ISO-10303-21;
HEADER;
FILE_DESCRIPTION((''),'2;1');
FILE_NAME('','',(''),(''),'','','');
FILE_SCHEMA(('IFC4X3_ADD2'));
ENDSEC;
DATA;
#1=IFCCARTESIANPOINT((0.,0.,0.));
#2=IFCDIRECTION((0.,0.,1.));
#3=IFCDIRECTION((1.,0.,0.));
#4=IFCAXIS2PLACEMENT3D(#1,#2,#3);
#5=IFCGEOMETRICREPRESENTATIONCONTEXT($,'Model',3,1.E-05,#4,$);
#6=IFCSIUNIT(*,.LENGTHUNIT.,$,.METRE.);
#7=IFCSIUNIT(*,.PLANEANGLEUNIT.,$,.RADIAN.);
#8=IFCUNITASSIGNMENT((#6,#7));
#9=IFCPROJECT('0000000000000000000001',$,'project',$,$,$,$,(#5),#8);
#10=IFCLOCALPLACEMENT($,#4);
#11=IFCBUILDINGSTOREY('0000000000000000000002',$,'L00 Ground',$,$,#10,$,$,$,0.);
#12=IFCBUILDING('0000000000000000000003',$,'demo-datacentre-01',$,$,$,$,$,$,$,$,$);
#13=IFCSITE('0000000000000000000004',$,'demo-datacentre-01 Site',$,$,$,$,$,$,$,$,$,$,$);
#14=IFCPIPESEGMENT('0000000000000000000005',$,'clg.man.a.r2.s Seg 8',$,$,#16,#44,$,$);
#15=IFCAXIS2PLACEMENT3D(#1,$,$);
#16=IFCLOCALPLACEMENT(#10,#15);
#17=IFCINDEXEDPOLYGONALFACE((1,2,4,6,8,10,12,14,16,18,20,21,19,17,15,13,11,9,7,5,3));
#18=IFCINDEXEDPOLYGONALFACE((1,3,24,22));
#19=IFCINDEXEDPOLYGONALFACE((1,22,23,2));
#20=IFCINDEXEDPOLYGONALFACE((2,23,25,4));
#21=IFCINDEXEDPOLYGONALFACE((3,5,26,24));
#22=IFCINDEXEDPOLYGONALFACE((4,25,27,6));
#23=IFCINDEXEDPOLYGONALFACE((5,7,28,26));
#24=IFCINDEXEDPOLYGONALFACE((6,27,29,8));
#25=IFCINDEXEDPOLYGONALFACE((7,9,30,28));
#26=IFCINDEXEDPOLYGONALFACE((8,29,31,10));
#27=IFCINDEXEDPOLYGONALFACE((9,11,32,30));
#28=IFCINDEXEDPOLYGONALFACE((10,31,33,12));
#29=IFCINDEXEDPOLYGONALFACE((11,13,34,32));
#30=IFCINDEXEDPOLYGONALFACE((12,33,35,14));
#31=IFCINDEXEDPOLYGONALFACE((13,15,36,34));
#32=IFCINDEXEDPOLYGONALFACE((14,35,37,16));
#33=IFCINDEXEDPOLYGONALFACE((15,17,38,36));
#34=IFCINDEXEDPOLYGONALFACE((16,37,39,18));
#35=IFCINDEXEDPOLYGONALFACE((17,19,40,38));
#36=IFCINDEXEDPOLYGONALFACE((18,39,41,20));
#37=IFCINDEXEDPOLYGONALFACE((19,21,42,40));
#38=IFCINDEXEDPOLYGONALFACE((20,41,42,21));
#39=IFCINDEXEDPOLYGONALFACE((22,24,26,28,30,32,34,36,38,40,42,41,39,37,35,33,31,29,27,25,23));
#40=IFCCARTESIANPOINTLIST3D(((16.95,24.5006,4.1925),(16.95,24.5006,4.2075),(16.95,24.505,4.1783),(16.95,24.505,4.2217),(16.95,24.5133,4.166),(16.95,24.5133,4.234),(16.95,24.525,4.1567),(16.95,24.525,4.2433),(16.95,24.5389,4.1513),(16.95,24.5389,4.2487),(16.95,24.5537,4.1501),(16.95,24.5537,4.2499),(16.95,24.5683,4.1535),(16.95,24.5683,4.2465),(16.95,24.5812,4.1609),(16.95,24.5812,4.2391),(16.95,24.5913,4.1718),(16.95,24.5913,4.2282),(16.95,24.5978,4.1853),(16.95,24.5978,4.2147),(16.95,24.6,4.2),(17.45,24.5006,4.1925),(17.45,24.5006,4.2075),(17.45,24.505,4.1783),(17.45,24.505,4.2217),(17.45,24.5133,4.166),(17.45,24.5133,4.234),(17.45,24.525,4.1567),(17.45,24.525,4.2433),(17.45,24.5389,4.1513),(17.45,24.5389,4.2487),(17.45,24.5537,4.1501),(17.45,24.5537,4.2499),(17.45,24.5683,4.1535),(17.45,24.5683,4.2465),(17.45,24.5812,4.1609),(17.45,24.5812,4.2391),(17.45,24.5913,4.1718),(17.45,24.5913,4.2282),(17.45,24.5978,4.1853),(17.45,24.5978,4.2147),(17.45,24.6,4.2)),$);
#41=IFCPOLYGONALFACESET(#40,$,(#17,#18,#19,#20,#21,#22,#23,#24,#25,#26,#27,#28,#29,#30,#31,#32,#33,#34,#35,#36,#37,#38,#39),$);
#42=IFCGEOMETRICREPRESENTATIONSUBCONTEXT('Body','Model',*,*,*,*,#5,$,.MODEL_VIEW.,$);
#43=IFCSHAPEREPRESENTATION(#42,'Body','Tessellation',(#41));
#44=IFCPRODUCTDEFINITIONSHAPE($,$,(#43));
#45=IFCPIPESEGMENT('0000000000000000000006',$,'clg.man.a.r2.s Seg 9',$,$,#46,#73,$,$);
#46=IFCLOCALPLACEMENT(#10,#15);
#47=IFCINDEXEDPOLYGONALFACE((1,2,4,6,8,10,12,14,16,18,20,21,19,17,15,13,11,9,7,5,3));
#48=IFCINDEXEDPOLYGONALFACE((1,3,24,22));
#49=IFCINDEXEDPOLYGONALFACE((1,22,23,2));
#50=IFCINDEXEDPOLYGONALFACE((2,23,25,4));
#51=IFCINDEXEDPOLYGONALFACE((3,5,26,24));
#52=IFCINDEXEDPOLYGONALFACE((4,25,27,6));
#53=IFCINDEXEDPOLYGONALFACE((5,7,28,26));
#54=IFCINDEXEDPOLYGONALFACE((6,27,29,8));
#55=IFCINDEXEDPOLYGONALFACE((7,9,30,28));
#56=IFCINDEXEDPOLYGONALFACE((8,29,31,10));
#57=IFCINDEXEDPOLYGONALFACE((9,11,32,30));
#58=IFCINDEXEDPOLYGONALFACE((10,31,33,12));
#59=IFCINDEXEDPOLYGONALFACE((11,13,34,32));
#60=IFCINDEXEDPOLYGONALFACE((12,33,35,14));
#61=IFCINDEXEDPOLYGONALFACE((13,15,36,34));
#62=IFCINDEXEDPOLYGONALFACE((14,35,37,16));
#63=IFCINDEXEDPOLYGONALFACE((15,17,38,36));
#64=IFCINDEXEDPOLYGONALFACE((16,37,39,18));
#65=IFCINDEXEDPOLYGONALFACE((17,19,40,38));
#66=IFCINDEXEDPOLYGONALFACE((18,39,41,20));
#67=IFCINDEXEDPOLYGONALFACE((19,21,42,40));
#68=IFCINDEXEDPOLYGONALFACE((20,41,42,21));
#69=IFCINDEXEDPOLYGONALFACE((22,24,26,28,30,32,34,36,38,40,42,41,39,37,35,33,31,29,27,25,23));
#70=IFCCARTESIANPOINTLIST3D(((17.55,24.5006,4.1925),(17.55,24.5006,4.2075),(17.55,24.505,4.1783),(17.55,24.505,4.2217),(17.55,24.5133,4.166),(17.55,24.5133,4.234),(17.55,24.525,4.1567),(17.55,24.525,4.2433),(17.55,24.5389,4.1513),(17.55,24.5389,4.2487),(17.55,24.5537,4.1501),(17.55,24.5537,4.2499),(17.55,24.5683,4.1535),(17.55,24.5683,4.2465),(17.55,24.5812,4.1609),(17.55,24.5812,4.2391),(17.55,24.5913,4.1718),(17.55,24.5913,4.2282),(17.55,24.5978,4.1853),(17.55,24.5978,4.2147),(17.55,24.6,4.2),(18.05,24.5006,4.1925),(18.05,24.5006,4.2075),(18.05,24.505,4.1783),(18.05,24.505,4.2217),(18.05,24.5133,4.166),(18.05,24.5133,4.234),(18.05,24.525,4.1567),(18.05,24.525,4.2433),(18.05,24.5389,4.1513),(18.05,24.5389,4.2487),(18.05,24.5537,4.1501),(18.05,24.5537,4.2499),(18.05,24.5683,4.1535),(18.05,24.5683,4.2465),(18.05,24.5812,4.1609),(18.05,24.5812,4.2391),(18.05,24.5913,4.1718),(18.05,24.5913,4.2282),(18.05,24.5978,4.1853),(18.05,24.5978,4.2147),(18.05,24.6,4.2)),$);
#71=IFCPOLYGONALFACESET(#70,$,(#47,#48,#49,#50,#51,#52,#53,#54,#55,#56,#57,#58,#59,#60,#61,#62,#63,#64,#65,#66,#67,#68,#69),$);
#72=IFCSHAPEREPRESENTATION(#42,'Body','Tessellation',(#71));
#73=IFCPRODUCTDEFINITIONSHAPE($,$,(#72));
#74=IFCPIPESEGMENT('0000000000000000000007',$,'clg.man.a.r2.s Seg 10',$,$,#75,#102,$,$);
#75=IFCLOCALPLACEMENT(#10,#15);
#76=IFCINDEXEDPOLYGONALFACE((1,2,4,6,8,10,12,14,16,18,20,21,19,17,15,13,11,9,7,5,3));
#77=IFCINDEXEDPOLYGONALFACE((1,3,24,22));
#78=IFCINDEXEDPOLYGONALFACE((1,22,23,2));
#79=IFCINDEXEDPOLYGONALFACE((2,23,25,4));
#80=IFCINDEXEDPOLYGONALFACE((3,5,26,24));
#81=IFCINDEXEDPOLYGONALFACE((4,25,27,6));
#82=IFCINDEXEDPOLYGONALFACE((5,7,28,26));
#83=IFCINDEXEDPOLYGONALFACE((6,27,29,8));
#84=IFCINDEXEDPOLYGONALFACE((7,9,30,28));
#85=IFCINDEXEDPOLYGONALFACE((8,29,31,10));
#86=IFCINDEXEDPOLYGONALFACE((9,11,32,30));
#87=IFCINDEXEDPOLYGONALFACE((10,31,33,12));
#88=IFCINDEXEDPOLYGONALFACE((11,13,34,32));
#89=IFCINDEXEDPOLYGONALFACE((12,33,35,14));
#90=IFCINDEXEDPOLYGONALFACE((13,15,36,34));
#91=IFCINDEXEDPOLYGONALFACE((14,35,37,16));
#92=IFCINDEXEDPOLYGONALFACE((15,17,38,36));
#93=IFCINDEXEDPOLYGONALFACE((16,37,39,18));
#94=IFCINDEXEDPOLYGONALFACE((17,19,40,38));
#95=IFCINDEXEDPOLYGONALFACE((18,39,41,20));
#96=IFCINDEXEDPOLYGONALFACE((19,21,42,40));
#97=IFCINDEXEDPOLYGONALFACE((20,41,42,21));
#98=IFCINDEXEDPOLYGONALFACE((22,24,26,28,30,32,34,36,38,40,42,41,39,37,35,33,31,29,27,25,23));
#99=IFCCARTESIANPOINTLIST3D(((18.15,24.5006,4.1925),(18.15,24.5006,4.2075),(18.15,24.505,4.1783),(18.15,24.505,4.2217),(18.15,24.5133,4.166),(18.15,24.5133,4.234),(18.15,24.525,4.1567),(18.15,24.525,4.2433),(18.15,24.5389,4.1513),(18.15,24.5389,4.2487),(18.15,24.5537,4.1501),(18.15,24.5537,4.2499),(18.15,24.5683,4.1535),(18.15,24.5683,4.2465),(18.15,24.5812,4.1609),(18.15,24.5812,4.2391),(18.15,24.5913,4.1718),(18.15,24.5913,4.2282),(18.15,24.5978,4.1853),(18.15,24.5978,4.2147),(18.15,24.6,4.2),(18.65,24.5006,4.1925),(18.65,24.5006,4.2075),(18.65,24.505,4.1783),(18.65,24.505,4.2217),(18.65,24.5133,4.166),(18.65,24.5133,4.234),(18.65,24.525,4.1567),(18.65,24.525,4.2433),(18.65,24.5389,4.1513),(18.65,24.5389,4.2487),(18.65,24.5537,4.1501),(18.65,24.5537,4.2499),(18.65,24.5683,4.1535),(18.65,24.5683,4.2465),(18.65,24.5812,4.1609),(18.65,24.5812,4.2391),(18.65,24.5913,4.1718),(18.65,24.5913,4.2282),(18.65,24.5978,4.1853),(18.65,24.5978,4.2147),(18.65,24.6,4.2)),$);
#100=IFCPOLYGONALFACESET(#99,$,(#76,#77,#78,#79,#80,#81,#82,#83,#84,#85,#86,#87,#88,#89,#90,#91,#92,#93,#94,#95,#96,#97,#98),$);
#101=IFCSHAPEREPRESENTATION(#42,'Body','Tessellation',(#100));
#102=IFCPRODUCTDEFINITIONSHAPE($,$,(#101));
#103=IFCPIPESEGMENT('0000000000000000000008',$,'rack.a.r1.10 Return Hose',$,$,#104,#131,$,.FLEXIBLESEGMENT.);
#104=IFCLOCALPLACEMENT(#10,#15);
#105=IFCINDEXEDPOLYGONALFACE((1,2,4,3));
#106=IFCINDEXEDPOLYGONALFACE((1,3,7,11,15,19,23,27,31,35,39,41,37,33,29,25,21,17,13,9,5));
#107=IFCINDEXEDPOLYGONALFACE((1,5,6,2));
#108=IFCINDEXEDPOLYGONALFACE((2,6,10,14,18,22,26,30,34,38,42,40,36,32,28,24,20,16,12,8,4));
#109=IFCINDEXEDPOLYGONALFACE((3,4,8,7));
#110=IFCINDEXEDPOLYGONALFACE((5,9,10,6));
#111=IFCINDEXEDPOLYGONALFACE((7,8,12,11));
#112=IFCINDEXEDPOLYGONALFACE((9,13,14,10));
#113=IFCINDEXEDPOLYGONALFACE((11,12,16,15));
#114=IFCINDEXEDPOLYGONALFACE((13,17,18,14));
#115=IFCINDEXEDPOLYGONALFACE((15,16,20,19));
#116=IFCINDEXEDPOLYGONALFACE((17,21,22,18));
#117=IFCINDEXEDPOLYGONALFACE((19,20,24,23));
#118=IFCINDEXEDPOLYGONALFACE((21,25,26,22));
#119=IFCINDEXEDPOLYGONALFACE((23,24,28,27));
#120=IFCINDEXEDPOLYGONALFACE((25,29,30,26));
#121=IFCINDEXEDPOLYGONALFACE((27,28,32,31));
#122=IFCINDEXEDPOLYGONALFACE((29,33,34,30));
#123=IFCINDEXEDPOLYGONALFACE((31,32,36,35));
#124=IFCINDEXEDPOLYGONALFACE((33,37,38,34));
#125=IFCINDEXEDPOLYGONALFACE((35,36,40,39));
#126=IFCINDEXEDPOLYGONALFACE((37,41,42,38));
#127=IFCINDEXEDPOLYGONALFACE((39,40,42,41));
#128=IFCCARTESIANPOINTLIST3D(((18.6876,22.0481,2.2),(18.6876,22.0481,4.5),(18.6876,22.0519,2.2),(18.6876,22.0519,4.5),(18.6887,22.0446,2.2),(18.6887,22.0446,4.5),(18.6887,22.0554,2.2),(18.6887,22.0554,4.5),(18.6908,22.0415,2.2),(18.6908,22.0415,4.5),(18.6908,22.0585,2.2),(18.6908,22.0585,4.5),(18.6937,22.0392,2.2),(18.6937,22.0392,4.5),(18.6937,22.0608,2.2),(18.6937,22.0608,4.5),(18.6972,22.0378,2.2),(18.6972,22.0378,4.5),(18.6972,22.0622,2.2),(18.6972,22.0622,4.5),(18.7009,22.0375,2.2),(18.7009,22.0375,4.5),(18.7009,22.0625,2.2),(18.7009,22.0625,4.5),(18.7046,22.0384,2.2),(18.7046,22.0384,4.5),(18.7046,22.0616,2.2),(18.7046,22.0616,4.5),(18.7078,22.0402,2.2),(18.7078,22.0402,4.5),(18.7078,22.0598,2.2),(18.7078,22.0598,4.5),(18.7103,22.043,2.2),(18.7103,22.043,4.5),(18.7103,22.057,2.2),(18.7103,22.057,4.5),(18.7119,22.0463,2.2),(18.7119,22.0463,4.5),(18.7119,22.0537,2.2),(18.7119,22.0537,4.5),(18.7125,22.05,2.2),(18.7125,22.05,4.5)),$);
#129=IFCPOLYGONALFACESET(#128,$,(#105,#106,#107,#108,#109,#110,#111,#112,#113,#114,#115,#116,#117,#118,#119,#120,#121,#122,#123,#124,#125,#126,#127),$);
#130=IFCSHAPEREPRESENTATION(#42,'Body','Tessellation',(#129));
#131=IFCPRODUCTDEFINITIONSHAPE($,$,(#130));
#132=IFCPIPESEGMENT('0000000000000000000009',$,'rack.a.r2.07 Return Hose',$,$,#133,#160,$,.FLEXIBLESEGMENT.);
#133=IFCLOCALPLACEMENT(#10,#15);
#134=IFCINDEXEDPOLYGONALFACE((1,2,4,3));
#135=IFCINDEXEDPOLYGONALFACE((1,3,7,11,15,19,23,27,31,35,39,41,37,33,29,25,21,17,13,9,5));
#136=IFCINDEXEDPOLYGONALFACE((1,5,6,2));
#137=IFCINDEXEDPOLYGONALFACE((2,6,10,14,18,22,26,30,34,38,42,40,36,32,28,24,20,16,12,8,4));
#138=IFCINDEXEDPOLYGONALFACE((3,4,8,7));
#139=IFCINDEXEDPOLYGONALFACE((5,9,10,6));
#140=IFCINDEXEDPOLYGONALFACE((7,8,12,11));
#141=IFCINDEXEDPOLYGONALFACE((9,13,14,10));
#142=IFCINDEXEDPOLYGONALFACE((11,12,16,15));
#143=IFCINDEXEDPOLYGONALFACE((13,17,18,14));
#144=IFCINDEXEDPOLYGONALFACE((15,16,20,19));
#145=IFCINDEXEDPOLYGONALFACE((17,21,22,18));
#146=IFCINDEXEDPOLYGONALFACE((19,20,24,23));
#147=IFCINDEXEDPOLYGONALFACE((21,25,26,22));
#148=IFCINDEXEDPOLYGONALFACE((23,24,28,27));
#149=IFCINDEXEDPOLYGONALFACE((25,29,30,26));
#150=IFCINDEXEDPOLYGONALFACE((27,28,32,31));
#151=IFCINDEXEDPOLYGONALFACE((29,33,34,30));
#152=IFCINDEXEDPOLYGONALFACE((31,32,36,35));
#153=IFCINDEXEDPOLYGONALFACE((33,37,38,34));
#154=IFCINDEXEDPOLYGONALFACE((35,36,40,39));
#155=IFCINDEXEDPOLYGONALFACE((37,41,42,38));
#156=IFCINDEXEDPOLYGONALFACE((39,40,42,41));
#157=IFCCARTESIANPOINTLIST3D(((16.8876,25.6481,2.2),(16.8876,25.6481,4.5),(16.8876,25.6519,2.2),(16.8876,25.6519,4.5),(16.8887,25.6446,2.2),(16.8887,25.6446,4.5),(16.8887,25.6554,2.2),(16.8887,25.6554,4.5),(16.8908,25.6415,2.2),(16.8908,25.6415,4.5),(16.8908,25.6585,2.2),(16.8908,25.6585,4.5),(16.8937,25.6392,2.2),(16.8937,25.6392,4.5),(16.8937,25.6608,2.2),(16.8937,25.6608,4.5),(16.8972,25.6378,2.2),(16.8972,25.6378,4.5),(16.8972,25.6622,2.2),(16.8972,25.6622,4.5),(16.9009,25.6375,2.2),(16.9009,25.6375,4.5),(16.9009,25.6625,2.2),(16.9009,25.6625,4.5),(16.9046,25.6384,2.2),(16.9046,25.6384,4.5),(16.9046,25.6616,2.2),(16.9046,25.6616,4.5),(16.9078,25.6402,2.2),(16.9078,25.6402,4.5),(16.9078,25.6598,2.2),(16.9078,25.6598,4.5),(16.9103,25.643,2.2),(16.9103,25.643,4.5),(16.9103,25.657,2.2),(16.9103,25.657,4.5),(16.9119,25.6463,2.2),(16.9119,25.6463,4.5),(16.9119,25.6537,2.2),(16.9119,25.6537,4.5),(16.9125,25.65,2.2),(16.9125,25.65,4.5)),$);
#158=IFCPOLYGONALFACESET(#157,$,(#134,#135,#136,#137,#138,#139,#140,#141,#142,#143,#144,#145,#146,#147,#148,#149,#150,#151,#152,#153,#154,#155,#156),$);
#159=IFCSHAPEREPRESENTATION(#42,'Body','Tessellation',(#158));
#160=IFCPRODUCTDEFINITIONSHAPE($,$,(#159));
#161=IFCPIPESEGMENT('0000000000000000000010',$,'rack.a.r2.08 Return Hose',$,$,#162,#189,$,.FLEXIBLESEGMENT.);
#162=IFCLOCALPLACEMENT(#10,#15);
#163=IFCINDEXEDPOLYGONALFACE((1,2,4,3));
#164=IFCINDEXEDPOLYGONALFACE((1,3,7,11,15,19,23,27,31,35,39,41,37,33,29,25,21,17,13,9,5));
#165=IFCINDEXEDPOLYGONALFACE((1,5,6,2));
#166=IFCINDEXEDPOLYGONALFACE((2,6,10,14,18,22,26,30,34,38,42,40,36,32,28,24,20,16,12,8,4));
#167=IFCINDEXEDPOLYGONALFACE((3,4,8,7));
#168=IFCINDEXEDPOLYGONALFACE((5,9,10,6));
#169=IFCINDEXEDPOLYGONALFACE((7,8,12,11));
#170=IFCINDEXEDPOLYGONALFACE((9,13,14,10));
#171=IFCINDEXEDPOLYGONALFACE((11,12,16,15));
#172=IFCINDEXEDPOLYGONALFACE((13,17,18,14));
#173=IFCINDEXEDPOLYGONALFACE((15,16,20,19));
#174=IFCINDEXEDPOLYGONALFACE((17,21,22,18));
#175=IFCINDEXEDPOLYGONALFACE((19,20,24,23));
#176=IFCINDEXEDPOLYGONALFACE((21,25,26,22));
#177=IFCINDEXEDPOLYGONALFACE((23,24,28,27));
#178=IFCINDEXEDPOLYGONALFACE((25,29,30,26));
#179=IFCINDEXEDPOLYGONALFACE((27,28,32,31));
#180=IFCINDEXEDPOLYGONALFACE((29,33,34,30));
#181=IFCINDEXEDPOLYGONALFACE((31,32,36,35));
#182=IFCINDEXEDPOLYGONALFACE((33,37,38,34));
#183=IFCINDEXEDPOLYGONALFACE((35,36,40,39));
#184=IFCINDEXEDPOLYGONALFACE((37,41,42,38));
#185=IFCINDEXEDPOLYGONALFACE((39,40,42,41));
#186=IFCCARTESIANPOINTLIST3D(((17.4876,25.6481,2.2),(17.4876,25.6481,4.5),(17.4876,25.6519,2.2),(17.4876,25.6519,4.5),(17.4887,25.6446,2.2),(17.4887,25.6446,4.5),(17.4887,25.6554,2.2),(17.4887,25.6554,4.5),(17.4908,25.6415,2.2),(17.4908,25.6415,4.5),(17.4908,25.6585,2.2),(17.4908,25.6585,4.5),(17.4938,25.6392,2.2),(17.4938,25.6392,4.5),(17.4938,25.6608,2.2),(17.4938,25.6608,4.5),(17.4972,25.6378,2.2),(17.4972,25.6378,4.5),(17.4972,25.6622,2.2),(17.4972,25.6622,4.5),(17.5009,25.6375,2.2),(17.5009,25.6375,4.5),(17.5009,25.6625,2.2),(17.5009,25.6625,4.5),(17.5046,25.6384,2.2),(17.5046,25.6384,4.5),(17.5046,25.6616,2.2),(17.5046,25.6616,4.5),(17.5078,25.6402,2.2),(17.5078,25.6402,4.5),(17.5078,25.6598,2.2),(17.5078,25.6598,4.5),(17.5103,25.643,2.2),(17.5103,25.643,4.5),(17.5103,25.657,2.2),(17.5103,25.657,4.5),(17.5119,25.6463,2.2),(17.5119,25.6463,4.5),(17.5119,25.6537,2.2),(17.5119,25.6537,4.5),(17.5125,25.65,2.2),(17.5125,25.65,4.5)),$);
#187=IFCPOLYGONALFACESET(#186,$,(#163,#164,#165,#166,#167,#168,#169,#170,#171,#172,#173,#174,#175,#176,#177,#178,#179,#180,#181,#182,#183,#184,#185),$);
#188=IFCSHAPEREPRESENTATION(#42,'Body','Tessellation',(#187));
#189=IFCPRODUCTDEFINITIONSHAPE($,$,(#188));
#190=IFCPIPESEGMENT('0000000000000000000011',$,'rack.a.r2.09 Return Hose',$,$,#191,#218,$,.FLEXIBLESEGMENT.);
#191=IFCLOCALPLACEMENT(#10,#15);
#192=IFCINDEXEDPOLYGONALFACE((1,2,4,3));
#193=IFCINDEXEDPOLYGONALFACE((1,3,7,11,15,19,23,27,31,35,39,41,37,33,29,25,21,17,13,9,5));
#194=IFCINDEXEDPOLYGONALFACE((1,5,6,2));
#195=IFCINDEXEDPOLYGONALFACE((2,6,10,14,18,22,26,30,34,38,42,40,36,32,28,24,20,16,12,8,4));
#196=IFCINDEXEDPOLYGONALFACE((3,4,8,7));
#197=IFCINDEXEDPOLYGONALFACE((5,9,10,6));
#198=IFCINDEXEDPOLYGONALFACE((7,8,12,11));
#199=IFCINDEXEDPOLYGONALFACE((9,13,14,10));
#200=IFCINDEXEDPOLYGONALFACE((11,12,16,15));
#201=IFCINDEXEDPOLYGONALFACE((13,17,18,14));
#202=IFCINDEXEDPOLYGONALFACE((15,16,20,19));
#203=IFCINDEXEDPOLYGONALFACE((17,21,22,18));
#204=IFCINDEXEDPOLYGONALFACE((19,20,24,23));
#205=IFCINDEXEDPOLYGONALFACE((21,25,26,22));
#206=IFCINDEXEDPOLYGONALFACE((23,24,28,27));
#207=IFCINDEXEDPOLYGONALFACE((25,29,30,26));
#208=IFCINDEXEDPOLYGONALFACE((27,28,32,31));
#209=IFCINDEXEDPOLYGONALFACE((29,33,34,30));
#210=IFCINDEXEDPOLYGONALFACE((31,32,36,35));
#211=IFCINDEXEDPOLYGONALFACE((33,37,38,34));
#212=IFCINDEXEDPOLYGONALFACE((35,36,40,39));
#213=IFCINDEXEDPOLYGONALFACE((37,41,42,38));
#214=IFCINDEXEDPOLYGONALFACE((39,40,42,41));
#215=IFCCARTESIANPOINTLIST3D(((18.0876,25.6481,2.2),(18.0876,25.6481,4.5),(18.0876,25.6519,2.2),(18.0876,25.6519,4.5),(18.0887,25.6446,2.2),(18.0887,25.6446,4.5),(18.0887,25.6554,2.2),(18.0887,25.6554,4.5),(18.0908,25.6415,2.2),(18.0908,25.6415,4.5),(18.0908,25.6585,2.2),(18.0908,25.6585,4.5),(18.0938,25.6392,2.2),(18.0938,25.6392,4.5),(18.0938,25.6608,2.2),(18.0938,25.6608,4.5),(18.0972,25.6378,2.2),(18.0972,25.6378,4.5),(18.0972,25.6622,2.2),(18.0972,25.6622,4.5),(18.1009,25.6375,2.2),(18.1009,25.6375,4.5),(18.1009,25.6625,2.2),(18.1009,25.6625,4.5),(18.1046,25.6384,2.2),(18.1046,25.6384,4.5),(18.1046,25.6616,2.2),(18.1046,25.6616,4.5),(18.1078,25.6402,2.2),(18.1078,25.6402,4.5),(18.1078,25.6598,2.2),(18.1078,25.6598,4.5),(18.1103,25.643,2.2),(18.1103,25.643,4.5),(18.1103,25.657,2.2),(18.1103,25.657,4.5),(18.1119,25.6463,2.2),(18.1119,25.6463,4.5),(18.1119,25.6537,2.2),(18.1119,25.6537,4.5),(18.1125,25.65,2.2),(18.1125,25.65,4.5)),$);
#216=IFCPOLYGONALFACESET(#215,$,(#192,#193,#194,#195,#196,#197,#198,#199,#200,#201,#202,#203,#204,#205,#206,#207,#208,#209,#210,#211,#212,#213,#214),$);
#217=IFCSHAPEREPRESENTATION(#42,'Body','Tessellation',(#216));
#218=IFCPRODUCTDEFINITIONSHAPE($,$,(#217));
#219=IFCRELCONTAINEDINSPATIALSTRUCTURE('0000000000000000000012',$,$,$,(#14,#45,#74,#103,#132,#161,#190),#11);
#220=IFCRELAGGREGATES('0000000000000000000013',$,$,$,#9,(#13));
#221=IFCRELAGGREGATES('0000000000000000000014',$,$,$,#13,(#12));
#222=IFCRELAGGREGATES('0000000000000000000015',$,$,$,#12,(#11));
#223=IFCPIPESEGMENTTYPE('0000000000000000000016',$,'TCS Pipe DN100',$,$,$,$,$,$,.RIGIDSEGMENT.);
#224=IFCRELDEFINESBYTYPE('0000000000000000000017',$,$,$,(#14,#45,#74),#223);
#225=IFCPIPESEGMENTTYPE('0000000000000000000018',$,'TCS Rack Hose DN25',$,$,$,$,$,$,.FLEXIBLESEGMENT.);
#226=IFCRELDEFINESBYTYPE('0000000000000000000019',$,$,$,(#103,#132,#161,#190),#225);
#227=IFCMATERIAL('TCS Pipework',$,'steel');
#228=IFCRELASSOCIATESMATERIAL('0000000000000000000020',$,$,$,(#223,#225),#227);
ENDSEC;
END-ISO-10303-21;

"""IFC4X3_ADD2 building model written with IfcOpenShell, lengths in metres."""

from ifc_helpers import new_model, si_unit, frame, origin_with_axes, place, context, subcontext, project, spatial, circle, extrude, material, type_object, element, save


model = new_model("IFC4X3_ADD2")

# Units and contexts
model_context = context("Model", 3, precision=1e-05, world=origin_with_axes())
body_context = subcontext(model_context, "Body", "Model", "MODEL_VIEW")
ifc_project = project(units=[si_unit("LENGTHUNIT", "METRE"), si_unit("PLANEANGLEUNIT", "RADIAN")], contexts=[model_context])

# Site, building, storey
site = spatial("IfcSite", under=ifc_project, Name="demo-datacentre-01 Site")
building = spatial("IfcBuilding", under=site, Name="demo-datacentre-01")
storey_placement = place(None, origin_with_axes())
storey = spatial("IfcBuildingStorey", under=building, at=storey_placement, Name="L00 Ground", Elevation=0.0)

# Shared definitions
ifc_material = material(Name="TCS Pipework", Category="steel")

# Pipe segments
pipe_segment_type_1 = type_object("IfcPipeSegmentType", Name="TCS Pipe DN100", PredefinedType="RIGIDSEGMENT", material=ifc_material)
for number, where, z_axis, x_axis, name in (
    (1, (16.95, 24.55, 4.2), (1.0, 0.0, 0.0), (0.0, 1.0, 0.0), "clg.man.a.r2.s Seg 8"),
    (2, (17.55, 24.55, 4.2), (1.0, 0.0, 0.0), (0.0, 1.0, 0.0), "clg.man.a.r2.s Seg 9"),
):
    element("IfcPipeSegment", number, at=place(storey_placement, frame(where, z_axis=z_axis, x_axis=x_axis)), inside=storey, type_object=pipe_segment_type_1, Name=name, context=body_context, shape_type="SweptSolid", body=[
        extrude(circle(Radius=0.05), origin_with_axes(), (0.0, 0.0, 1.0), 0.5),
    ])
pipe_segment_1_placement = place(storey_placement, frame((18.15, 24.55, 4.2), z_axis=(1.0, 0.0, 0.0), x_axis=(0.0, 1.0, 0.0)))
element("IfcPipeSegment", 3, at=pipe_segment_1_placement, inside=storey, type_object=pipe_segment_type_1, Name="clg.man.a.r2.s Seg 10", context=body_context, shape_type="SweptSolid", body=[
    extrude(circle(Radius=0.05), origin_with_axes(), (0.0, 0.0, 1.0), 0.5),
])
pipe_segment_type_2 = type_object("IfcPipeSegmentType", Name="TCS Rack Hose DN25", PredefinedType="FLEXIBLESEGMENT", material=ifc_material)
for number, where, z_axis, x_axis, name in (
    (4, (18.7, 22.05, 4.5), (0.0, 0.0, -1.0), (1.0, 0.0, 0.0), "rack.a.r1.10 Return Hose"),
    (5, (16.9, 25.65, 4.5), (0.0, 0.0, -1.0), (1.0, 0.0, 0.0), "rack.a.r2.07 Return Hose"),
    (6, (17.5, 25.65, 4.5), (0.0, 0.0, -1.0), (1.0, 0.0, 0.0), "rack.a.r2.08 Return Hose"),
    (7, (18.1, 25.65, 4.5), (0.0, 0.0, -1.0), (1.0, 0.0, 0.0), "rack.a.r2.09 Return Hose"),
):
    element("IfcPipeSegment", number, at=place(storey_placement, frame(where, z_axis=z_axis, x_axis=x_axis)), inside=storey, type_object=pipe_segment_type_2, Name=name, PredefinedType="FLEXIBLESEGMENT", context=body_context, shape_type="SweptSolid", body=[
        extrude(circle(Radius=0.0125), origin_with_axes(), (0.0, 0.0, 1.0), 2.3),
    ])

save(model, "model.ifc")
